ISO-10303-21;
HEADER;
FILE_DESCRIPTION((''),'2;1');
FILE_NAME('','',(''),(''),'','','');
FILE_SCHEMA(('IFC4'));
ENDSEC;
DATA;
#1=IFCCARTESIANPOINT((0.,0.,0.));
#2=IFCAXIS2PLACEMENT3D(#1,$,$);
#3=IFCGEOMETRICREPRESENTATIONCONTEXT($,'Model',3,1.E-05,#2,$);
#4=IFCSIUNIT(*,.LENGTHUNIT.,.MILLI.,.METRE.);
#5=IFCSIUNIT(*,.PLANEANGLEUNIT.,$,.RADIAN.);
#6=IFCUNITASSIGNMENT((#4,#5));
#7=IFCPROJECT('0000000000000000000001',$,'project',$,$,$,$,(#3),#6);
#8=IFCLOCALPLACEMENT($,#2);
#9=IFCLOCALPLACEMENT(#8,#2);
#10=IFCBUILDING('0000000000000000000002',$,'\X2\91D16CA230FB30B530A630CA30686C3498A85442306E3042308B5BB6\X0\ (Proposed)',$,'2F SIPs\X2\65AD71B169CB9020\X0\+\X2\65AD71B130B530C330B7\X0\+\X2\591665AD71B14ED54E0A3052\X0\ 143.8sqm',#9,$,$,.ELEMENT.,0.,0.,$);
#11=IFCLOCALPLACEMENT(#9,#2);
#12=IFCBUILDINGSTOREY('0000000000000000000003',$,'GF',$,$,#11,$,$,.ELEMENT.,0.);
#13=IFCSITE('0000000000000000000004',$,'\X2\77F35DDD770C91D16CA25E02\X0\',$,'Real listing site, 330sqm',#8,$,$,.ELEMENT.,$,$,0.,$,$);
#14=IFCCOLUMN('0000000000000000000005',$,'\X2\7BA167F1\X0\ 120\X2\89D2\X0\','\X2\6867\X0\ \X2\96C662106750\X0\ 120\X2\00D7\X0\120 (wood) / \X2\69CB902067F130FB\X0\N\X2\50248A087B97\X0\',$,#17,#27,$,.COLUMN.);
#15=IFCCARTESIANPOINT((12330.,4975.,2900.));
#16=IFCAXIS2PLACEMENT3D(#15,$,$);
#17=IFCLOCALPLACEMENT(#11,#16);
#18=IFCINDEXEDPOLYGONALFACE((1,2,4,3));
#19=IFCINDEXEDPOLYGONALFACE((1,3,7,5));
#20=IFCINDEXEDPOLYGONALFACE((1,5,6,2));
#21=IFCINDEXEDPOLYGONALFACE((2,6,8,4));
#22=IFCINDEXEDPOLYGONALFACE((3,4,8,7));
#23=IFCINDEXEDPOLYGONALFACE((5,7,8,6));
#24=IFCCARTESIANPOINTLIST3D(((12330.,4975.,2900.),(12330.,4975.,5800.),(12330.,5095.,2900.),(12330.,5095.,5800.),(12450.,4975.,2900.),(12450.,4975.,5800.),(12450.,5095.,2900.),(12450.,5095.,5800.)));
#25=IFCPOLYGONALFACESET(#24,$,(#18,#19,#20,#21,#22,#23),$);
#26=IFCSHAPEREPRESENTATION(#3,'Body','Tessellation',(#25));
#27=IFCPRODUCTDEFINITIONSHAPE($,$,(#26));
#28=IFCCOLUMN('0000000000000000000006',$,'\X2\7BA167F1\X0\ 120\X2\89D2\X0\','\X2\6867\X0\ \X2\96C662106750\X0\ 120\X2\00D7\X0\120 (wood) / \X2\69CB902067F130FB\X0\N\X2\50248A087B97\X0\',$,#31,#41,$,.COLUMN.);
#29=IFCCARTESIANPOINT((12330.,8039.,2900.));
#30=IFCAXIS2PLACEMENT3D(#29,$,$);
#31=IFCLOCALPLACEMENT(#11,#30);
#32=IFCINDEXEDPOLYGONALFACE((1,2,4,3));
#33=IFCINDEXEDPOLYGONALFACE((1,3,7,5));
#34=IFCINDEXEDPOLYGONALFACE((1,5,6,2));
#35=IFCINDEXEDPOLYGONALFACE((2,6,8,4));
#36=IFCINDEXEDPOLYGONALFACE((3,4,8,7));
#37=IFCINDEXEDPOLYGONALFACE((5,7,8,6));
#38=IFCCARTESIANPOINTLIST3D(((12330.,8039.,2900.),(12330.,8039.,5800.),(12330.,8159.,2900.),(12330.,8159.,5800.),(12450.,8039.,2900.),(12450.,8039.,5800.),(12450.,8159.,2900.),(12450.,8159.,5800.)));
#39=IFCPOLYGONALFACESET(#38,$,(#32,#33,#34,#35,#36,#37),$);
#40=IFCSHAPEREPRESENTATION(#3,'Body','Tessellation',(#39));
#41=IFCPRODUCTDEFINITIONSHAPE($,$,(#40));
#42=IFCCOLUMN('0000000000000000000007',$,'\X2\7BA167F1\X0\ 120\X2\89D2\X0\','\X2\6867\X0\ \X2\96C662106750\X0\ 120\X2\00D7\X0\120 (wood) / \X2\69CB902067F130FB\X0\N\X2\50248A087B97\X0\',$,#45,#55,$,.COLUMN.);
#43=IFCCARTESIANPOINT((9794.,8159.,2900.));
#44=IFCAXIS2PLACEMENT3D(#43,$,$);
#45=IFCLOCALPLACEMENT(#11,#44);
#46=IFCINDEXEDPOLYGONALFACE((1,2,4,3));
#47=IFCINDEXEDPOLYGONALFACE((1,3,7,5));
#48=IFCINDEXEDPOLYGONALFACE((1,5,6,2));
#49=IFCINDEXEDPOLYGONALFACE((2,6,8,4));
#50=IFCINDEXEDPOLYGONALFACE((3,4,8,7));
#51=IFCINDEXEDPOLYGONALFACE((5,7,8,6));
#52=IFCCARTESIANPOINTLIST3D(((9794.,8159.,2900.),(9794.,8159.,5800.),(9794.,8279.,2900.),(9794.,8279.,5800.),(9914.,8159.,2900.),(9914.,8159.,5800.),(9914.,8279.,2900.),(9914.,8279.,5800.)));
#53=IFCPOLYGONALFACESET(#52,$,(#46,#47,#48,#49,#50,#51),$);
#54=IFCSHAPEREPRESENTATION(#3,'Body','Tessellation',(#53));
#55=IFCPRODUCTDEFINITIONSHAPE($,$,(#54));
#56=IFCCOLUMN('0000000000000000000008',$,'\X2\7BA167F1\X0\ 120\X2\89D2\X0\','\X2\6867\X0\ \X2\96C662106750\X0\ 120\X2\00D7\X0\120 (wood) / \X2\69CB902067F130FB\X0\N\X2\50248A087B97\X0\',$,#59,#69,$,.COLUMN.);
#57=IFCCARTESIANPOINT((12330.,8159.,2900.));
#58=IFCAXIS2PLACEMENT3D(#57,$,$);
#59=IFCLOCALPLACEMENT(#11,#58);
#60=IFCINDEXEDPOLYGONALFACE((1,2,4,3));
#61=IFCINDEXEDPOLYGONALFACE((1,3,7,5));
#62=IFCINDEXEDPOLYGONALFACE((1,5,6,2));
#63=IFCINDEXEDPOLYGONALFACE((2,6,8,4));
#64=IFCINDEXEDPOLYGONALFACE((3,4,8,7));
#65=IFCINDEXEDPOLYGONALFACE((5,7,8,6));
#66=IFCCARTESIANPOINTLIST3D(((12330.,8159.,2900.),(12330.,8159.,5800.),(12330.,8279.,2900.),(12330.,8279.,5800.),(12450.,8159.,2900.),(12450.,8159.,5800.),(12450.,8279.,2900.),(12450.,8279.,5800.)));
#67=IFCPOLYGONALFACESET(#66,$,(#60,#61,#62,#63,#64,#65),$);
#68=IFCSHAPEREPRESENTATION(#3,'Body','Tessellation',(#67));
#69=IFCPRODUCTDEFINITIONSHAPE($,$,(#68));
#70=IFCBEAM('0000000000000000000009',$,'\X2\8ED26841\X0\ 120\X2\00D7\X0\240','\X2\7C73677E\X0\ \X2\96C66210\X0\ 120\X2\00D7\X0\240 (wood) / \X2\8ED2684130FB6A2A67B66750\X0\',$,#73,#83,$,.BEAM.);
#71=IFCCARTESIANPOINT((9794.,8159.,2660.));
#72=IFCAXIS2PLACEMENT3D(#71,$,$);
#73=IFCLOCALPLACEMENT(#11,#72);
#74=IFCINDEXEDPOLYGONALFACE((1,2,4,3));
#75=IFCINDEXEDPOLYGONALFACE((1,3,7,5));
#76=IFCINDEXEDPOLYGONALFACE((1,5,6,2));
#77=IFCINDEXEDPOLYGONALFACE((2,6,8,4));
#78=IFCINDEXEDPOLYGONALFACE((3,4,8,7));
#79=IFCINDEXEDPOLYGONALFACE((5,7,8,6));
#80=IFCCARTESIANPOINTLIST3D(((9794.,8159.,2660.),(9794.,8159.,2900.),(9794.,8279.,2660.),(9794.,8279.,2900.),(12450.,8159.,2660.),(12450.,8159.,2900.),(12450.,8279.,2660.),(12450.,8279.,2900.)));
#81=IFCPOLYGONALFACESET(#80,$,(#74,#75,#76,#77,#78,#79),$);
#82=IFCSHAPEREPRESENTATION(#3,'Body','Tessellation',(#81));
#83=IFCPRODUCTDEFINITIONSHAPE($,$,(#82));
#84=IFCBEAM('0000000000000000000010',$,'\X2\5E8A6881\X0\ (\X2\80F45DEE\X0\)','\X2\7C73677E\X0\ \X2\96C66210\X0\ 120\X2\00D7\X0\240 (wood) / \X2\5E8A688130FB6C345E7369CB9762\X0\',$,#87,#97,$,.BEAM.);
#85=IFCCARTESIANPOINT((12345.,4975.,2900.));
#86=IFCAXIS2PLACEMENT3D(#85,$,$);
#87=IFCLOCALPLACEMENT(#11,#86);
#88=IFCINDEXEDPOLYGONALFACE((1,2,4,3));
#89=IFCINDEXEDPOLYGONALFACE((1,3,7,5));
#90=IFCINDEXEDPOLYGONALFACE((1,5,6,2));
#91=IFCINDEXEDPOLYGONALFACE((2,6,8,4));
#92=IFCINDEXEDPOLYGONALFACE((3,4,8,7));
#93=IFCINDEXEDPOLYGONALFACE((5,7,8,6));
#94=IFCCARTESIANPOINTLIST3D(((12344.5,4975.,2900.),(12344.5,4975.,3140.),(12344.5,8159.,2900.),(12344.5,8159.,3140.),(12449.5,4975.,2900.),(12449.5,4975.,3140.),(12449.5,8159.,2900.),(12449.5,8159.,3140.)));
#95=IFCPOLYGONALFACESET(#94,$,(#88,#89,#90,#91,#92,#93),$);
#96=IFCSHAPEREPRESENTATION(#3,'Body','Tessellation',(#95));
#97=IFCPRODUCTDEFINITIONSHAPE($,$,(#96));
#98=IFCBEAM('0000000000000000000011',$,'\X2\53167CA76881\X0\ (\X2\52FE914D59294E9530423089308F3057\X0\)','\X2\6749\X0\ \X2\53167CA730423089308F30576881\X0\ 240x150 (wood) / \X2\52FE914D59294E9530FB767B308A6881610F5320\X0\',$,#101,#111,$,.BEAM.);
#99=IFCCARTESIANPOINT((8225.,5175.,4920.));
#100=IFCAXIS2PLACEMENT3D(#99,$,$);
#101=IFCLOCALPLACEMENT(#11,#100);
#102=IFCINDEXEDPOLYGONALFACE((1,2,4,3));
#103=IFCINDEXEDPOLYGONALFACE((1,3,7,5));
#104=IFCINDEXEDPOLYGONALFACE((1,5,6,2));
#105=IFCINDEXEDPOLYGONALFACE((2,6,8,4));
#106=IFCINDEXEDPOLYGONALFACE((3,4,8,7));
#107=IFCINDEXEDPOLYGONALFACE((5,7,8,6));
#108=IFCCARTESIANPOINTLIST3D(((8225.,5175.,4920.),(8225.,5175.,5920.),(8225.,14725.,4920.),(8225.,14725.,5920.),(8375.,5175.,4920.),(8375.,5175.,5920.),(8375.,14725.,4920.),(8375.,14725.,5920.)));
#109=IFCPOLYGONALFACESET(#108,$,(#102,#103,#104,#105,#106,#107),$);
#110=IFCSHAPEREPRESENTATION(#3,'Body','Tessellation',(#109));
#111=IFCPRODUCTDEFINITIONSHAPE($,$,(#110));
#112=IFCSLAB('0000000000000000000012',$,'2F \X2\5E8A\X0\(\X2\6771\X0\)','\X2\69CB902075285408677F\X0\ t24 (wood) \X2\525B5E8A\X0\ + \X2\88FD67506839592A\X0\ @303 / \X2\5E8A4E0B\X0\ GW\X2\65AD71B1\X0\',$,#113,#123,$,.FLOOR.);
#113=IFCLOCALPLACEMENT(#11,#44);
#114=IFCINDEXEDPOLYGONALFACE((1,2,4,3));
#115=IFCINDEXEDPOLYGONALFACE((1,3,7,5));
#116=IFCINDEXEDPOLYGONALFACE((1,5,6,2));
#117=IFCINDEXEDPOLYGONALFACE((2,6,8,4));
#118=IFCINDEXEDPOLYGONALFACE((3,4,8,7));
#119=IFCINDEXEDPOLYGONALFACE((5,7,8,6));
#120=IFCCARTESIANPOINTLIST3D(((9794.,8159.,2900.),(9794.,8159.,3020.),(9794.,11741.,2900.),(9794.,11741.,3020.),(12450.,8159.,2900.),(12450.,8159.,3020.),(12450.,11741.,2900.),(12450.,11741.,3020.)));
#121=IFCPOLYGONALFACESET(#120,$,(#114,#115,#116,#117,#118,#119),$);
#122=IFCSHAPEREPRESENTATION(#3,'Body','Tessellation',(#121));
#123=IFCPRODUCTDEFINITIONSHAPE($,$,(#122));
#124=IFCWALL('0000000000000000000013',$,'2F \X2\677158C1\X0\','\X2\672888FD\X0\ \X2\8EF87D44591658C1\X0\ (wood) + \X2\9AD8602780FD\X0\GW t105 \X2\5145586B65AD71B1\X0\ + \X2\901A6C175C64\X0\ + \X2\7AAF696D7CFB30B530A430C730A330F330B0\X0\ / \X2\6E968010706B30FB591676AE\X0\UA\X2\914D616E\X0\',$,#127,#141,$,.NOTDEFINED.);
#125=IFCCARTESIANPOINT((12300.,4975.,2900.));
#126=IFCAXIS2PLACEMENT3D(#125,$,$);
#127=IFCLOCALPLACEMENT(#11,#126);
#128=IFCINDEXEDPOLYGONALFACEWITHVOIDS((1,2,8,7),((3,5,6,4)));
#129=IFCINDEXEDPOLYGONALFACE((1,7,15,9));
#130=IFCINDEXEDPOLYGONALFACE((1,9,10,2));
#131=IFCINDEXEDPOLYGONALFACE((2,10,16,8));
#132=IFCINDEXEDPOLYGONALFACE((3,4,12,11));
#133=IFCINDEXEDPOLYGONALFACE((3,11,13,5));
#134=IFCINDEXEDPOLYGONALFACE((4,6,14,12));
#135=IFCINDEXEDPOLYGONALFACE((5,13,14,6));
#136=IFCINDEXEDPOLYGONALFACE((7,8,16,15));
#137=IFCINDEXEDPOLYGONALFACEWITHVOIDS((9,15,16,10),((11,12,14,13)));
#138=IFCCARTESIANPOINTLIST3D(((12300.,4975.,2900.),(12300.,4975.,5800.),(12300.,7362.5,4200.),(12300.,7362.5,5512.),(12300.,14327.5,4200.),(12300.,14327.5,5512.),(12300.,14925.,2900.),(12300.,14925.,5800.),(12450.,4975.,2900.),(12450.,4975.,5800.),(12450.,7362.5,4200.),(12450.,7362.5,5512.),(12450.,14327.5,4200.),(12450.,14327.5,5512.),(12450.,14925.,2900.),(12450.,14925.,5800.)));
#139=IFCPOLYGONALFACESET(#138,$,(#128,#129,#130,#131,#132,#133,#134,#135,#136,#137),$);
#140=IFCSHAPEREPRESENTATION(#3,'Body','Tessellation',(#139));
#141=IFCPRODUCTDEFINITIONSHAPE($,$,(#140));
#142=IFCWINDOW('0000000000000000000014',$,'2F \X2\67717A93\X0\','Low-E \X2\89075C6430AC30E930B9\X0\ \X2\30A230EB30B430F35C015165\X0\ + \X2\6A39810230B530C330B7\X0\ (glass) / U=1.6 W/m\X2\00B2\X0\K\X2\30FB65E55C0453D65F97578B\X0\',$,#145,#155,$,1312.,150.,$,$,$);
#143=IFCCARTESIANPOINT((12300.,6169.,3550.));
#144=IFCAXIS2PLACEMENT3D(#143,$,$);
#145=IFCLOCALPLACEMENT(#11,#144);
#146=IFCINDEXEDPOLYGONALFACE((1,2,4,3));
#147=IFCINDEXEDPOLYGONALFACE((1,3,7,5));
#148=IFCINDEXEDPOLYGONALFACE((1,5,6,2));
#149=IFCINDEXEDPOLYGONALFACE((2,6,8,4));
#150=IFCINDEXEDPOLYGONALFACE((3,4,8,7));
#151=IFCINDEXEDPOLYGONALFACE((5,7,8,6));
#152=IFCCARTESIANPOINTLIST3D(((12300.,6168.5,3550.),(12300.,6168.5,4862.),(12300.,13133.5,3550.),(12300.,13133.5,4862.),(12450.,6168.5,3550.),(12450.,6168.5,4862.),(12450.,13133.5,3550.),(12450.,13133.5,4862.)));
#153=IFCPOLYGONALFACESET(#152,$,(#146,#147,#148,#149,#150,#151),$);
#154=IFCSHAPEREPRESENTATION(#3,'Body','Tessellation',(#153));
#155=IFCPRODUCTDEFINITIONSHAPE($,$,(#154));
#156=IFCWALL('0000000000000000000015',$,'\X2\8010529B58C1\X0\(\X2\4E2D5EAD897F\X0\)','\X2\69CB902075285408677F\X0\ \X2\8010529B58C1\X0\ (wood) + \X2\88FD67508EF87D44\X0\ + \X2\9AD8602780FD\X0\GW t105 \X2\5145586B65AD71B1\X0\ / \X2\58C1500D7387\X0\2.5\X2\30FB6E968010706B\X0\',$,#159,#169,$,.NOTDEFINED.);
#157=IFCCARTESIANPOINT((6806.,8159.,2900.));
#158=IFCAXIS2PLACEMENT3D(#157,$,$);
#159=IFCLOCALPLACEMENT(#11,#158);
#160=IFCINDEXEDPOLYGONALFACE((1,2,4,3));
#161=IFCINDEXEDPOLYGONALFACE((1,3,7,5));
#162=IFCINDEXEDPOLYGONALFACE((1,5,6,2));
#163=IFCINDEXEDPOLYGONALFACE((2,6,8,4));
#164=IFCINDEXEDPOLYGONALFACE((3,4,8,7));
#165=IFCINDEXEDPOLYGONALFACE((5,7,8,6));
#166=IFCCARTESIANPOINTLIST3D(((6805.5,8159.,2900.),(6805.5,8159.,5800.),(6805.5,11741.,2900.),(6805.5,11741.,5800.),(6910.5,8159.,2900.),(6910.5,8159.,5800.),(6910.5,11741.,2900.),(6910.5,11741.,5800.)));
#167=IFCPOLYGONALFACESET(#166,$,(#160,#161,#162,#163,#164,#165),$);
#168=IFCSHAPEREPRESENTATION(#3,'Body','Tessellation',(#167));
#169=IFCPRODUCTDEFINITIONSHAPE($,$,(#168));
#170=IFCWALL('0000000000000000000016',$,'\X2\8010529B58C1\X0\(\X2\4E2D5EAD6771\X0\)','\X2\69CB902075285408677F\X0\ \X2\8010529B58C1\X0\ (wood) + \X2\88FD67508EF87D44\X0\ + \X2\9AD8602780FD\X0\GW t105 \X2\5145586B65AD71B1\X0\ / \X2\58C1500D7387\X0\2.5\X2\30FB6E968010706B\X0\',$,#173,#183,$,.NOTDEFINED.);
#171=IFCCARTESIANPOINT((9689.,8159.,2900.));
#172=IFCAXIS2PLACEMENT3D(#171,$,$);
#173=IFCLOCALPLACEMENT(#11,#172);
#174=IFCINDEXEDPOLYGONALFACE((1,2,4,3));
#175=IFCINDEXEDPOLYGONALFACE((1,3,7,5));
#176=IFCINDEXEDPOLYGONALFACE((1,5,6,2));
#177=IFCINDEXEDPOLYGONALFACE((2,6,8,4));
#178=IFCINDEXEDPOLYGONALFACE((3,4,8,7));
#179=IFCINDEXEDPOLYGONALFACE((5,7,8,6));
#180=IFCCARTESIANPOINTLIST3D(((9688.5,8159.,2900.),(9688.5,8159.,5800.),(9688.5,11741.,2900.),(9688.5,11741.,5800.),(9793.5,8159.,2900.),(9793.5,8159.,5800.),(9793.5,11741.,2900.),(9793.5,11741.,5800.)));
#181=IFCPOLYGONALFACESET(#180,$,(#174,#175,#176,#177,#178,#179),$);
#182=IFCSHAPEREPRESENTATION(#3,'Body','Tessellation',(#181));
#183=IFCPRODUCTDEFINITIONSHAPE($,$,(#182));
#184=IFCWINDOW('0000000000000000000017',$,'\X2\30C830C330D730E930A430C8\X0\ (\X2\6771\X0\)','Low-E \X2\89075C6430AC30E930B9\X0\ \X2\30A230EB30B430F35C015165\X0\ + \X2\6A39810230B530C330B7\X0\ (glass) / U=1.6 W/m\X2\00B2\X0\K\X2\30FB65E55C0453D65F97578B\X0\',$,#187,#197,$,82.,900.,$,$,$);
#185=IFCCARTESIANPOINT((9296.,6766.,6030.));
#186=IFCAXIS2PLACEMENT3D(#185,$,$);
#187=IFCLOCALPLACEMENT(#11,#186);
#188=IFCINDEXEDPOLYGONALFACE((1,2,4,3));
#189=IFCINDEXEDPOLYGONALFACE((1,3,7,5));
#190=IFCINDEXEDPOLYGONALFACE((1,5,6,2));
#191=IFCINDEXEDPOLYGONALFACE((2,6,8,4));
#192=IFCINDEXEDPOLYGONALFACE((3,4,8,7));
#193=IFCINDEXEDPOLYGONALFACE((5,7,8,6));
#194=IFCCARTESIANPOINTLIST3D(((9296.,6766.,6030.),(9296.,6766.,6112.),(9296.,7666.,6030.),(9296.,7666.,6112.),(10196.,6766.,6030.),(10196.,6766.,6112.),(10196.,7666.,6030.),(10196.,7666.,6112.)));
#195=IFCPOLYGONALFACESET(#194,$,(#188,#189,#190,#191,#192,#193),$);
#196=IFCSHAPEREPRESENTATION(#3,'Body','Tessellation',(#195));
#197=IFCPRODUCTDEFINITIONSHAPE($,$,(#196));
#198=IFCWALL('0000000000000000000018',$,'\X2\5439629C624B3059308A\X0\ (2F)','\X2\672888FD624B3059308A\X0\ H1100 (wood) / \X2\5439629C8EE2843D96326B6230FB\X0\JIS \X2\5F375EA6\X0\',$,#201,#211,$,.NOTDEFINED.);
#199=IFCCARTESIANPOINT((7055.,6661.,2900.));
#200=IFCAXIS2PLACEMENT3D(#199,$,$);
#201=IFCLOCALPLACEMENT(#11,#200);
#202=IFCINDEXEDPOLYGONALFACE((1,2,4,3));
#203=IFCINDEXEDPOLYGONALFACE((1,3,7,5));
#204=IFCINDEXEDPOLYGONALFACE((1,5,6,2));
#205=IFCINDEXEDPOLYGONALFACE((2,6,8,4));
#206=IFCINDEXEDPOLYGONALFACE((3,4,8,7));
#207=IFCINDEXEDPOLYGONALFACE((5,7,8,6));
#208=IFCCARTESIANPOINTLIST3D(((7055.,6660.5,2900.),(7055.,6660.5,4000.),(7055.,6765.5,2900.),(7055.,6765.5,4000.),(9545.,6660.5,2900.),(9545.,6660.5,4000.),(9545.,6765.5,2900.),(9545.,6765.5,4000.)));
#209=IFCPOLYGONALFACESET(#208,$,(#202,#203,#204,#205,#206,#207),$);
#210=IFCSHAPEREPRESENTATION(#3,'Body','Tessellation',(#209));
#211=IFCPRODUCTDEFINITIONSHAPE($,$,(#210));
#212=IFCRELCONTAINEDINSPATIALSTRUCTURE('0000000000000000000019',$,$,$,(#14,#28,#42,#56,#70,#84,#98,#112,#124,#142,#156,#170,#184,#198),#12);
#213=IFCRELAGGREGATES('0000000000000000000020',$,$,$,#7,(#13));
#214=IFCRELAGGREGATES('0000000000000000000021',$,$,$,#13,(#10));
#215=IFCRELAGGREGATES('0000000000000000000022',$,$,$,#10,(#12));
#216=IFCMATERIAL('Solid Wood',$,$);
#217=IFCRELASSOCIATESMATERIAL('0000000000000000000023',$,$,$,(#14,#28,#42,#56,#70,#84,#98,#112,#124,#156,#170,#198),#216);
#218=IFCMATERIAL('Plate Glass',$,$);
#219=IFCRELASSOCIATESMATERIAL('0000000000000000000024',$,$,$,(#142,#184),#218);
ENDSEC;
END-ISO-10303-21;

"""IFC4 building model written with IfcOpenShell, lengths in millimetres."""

from ifc_helpers import new_model, si_unit, frame, frame_2d, origin, place, context, project, spatial, rectangle, extrude, material, element, fill, save


model = new_model("IFC4")

# Units and contexts
model_context = context("Model", 3, precision=1e-05, world=origin())
ifc_project = project(units=[si_unit("LENGTHUNIT", "METRE", prefix="MILLI"), si_unit("PLANEANGLEUNIT", "RADIAN")], contexts=[model_context])

# Site, building, storey
site_placement = place(None, origin())
site = spatial("IfcSite", under=ifc_project, at=site_placement, Name="石川県金沢市", ObjectType="Real listing site, 330sqm", CompositionType="ELEMENT", RefElevation=0.0)
building_placement = place(site_placement, origin())
building = spatial("IfcBuilding", under=site, at=building_placement, Name="金沢・サウナと水風呂のある家 (Proposed)", ObjectType="2F SIPs断熱構造+断熱サッシ+外断熱仕上げ 143.8sqm", CompositionType="ELEMENT", ElevationOfRefHeight=0.0, ElevationOfTerrain=0.0)
storey_placement = place(building_placement, origin())
storey = spatial("IfcBuildingStorey", under=building, at=storey_placement, Name="GF", CompositionType="ELEMENT", Elevation=0.0)

# Columns
ifc_material_1 = material(Name="Solid Wood")
column_1_placement = place(storey_placement, frame((12330.0, 4975.0, 2900.0)))
element("IfcColumn", 1, at=column_1_placement, inside=storey, material=ifc_material_1, Name="管柱 120角", Description="桧 集成材 120×120 (wood) / 構造柱・N値計算", PredefinedType="COLUMN", context=model_context, shape_type="SweptSolid", body=[
    extrude(rectangle(XDim=120.0, YDim=120.0, at=frame_2d((60.0, 60.0))), frame((12330.0, 4975.0, 2900.0)), (0.0, 0.0, 1.0), 2900.0),
])
column_2_placement = place(storey_placement, frame((12330.0, 8039.0, 2900.0)))
element("IfcColumn", 2, at=column_2_placement, inside=storey, material=ifc_material_1, Name="管柱 120角", Description="桧 集成材 120×120 (wood) / 構造柱・N値計算", PredefinedType="COLUMN", context=model_context, shape_type="SweptSolid", body=[
    extrude(rectangle(XDim=120.0, YDim=120.0, at=frame_2d((60.0, 60.0))), frame((12330.0, 8039.0, 2900.0)), (0.0, 0.0, 1.0), 2900.0),
])
column_3_placement = place(storey_placement, frame((9794.0, 8159.0, 2900.0)))
element("IfcColumn", 3, at=column_3_placement, inside=storey, material=ifc_material_1, Name="管柱 120角", Description="桧 集成材 120×120 (wood) / 構造柱・N値計算", PredefinedType="COLUMN", context=model_context, shape_type="SweptSolid", body=[
    extrude(rectangle(XDim=120.0, YDim=120.0, at=frame_2d((60.0, 60.0))), frame((9794.0, 8159.0, 2900.0)), (0.0, 0.0, 1.0), 2900.0),
])
column_4_placement = place(storey_placement, frame((12330.0, 8159.0, 2900.0)))
element("IfcColumn", 4, at=column_4_placement, inside=storey, material=ifc_material_1, Name="管柱 120角", Description="桧 集成材 120×120 (wood) / 構造柱・N値計算", PredefinedType="COLUMN", context=model_context, shape_type="SweptSolid", body=[
    extrude(rectangle(XDim=120.0, YDim=120.0, at=frame_2d((60.0, 60.0))), frame((12330.0, 8159.0, 2900.0)), (0.0, 0.0, 1.0), 2900.0),
])

# Beams
beam_1_placement = place(storey_placement, frame((9794.0, 8159.0, 2660.0)))
element("IfcBeam", 5, at=beam_1_placement, inside=storey, material=ifc_material_1, Name="軒桁 120×240", Description="米松 集成 120×240 (wood) / 軒桁・横架材", PredefinedType="BEAM", context=model_context, shape_type="SweptSolid", body=[
    extrude(rectangle(XDim=2656.0, YDim=120.0, at=frame_2d((1328.0, 60.0))), frame((9794.0, 8159.0, 2660.0)), (0.0, 0.0, 1.0), 240.0),
])
beam_2_placement = place(storey_placement, frame((12345.0, 4975.0, 2900.0)))
element("IfcBeam", 6, at=beam_2_placement, inside=storey, material=ifc_material_1, Name="床梁 (胴差)", Description="米松 集成 120×240 (wood) / 床梁・水平構面", PredefinedType="BEAM", context=model_context, shape_type="SweptSolid", body=[
    extrude(rectangle(XDim=105.0, YDim=3184.0, at=frame_2d((52.0, 1592.0))), frame((12345.0, 4975.0, 2900.0)), (0.0, 0.0, 1.0), 240.0),
])
beam_3_placement = place(storey_placement, frame((8225.0, 5175.0, 4920.0)))
element("IfcBeam", 7, at=beam_3_placement, inside=storey, material=ifc_material_1, Name="化粧梁 (勾配天井あらわし)", Description="杉 化粧あらわし梁 240x150 (wood) / 勾配天井・登り梁意匠", PredefinedType="BEAM", context=model_context, shape_type="SweptSolid", body=[
    extrude(rectangle(XDim=150.0, YDim=9550.0, at=frame_2d((75.0, 4775.0))), frame((8225.0, 5175.0, 4920.0)), (0.0, 0.0, 1.0), 1000.0),
])

# Slab
slab_placement = place(storey_placement, frame((9794.0, 8159.0, 2900.0)))
element("IfcSlab", 8, at=slab_placement, inside=storey, material=ifc_material_1, Name="2F 床(東)", Description="構造用合板 t24 (wood) 剛床 + 製材根太 @303 / 床下 GW断熱", PredefinedType="FLOOR", context=model_context, shape_type="SweptSolid", body=[
    extrude(rectangle(XDim=2656.0, YDim=3582.0, at=frame_2d((1328.0, 1791.0))), frame((9794.0, 8159.0, 2900.0)), (0.0, 0.0, 1.0), 120.0),
])

# Wall, opening, window
wall_1_placement = place(storey_placement, frame((12300.0, 4975.0, 2900.0)))
wall_1 = element("IfcWall", 9, at=wall_1_placement, inside=storey, material=ifc_material_1, Name="2F 東壁", Description="木製 軸組外壁 (wood) + 高性能GW t105 充填断熱 + 通気層 + 窯業系サイディング / 準耐火・外皮UA配慮", PredefinedType="NOTDEFINED", context=model_context, shape_type="SweptSolid", body=[
    extrude(rectangle(XDim=150.0, YDim=9950.0, at=frame_2d((75.0, 4975.0))), frame((12300.0, 4975.0, 2900.0)), (0.0, 0.0, 1.0), 2900.0),
])
opening_placement = place(storey_placement, frame((12300.0, 6169.0, 3550.0)))
opening = element("IfcOpeningElement", 10, at=opening_placement, cuts=wall_1, PredefinedType="NOTDEFINED", context=model_context, shape_type="SweptSolid", body=[
    extrude(rectangle(XDim=150.0, YDim=6965.0, at=frame_2d((75.0, 3482.0))), frame((12300.0, 6169.0, 3550.0)), (0.0, 0.0, 1.0), 1312.0),
])
ifc_material_2 = material(Name="Plate Glass")
window_1_placement = place(storey_placement, frame((12300.0, 6169.0, 3550.0)))
window_1 = element("IfcWindow", 11, at=window_1_placement, inside=storey, material=ifc_material_2, Name="2F 東窓", Description="Low-E 複層ガラス アルゴン封入 + 樹脂サッシ (glass) / U=1.6 W/m²K・日射取得型", OverallHeight=1312.0, OverallWidth=150.0, context=model_context, shape_type="SweptSolid", body=[
    extrude(rectangle(XDim=150.0, YDim=6965.0, at=frame_2d((75.0, 3482.0))), frame((12300.0, 6169.0, 3550.0)), (0.0, 0.0, 1.0), 1312.0),
])
fill(opening, window_1)

# Walls
wall_2_placement = place(storey_placement, frame((6806.0, 8159.0, 2900.0)))
element("IfcWall", 12, at=wall_2_placement, inside=storey, material=ifc_material_1, Name="耐力壁(中庭西)", Description="構造用合板 耐力壁 (wood) + 製材軸組 + 高性能GW t105 充填断熱 / 壁倍率2.5・準耐火", PredefinedType="NOTDEFINED", context=model_context, shape_type="SweptSolid", body=[
    extrude(rectangle(XDim=105.0, YDim=3582.0, at=frame_2d((52.0, 1791.0))), frame((6806.0, 8159.0, 2900.0)), (0.0, 0.0, 1.0), 2900.0),
])
wall_3_placement = place(storey_placement, frame((9689.0, 8159.0, 2900.0)))
element("IfcWall", 13, at=wall_3_placement, inside=storey, material=ifc_material_1, Name="耐力壁(中庭東)", Description="構造用合板 耐力壁 (wood) + 製材軸組 + 高性能GW t105 充填断熱 / 壁倍率2.5・準耐火", PredefinedType="NOTDEFINED", context=model_context, shape_type="SweptSolid", body=[
    extrude(rectangle(XDim=105.0, YDim=3582.0, at=frame_2d((52.0, 1791.0))), frame((9689.0, 8159.0, 2900.0)), (0.0, 0.0, 1.0), 2900.0),
])

# Window
window_2_placement = place(storey_placement, frame((9296.0, 6766.0, 6030.0)))
element("IfcWindow", 14, at=window_2_placement, inside=storey, material=ifc_material_2, Name="トップライト (東)", Description="Low-E 複層ガラス アルゴン封入 + 樹脂サッシ (glass) / U=1.6 W/m²K・日射取得型", OverallHeight=82.0, OverallWidth=900.0, context=model_context, shape_type="SweptSolid", body=[
    extrude(rectangle(XDim=900.0, YDim=900.0, at=frame_2d((450.0, 450.0))), frame((9296.0, 6766.0, 6030.0)), (0.0, 0.0, 1.0), 82.0),
])

# Wall
wall_4_placement = place(storey_placement, frame((7055.0, 6661.0, 2900.0)))
element("IfcWall", 15, at=wall_4_placement, inside=storey, material=ifc_material_1, Name="吹抜手すり (2F)", Description="木製手すり H1100 (wood) / 吹抜転落防止・JIS 強度", PredefinedType="NOTDEFINED", context=model_context, shape_type="SweptSolid", body=[
    extrude(rectangle(XDim=2490.0, YDim=105.0, at=frame_2d((1245.0, 52.0))), frame((7055.0, 6661.0, 2900.0)), (0.0, 0.0, 1.0), 1100.0),
])

save(model, "model.ifc")
